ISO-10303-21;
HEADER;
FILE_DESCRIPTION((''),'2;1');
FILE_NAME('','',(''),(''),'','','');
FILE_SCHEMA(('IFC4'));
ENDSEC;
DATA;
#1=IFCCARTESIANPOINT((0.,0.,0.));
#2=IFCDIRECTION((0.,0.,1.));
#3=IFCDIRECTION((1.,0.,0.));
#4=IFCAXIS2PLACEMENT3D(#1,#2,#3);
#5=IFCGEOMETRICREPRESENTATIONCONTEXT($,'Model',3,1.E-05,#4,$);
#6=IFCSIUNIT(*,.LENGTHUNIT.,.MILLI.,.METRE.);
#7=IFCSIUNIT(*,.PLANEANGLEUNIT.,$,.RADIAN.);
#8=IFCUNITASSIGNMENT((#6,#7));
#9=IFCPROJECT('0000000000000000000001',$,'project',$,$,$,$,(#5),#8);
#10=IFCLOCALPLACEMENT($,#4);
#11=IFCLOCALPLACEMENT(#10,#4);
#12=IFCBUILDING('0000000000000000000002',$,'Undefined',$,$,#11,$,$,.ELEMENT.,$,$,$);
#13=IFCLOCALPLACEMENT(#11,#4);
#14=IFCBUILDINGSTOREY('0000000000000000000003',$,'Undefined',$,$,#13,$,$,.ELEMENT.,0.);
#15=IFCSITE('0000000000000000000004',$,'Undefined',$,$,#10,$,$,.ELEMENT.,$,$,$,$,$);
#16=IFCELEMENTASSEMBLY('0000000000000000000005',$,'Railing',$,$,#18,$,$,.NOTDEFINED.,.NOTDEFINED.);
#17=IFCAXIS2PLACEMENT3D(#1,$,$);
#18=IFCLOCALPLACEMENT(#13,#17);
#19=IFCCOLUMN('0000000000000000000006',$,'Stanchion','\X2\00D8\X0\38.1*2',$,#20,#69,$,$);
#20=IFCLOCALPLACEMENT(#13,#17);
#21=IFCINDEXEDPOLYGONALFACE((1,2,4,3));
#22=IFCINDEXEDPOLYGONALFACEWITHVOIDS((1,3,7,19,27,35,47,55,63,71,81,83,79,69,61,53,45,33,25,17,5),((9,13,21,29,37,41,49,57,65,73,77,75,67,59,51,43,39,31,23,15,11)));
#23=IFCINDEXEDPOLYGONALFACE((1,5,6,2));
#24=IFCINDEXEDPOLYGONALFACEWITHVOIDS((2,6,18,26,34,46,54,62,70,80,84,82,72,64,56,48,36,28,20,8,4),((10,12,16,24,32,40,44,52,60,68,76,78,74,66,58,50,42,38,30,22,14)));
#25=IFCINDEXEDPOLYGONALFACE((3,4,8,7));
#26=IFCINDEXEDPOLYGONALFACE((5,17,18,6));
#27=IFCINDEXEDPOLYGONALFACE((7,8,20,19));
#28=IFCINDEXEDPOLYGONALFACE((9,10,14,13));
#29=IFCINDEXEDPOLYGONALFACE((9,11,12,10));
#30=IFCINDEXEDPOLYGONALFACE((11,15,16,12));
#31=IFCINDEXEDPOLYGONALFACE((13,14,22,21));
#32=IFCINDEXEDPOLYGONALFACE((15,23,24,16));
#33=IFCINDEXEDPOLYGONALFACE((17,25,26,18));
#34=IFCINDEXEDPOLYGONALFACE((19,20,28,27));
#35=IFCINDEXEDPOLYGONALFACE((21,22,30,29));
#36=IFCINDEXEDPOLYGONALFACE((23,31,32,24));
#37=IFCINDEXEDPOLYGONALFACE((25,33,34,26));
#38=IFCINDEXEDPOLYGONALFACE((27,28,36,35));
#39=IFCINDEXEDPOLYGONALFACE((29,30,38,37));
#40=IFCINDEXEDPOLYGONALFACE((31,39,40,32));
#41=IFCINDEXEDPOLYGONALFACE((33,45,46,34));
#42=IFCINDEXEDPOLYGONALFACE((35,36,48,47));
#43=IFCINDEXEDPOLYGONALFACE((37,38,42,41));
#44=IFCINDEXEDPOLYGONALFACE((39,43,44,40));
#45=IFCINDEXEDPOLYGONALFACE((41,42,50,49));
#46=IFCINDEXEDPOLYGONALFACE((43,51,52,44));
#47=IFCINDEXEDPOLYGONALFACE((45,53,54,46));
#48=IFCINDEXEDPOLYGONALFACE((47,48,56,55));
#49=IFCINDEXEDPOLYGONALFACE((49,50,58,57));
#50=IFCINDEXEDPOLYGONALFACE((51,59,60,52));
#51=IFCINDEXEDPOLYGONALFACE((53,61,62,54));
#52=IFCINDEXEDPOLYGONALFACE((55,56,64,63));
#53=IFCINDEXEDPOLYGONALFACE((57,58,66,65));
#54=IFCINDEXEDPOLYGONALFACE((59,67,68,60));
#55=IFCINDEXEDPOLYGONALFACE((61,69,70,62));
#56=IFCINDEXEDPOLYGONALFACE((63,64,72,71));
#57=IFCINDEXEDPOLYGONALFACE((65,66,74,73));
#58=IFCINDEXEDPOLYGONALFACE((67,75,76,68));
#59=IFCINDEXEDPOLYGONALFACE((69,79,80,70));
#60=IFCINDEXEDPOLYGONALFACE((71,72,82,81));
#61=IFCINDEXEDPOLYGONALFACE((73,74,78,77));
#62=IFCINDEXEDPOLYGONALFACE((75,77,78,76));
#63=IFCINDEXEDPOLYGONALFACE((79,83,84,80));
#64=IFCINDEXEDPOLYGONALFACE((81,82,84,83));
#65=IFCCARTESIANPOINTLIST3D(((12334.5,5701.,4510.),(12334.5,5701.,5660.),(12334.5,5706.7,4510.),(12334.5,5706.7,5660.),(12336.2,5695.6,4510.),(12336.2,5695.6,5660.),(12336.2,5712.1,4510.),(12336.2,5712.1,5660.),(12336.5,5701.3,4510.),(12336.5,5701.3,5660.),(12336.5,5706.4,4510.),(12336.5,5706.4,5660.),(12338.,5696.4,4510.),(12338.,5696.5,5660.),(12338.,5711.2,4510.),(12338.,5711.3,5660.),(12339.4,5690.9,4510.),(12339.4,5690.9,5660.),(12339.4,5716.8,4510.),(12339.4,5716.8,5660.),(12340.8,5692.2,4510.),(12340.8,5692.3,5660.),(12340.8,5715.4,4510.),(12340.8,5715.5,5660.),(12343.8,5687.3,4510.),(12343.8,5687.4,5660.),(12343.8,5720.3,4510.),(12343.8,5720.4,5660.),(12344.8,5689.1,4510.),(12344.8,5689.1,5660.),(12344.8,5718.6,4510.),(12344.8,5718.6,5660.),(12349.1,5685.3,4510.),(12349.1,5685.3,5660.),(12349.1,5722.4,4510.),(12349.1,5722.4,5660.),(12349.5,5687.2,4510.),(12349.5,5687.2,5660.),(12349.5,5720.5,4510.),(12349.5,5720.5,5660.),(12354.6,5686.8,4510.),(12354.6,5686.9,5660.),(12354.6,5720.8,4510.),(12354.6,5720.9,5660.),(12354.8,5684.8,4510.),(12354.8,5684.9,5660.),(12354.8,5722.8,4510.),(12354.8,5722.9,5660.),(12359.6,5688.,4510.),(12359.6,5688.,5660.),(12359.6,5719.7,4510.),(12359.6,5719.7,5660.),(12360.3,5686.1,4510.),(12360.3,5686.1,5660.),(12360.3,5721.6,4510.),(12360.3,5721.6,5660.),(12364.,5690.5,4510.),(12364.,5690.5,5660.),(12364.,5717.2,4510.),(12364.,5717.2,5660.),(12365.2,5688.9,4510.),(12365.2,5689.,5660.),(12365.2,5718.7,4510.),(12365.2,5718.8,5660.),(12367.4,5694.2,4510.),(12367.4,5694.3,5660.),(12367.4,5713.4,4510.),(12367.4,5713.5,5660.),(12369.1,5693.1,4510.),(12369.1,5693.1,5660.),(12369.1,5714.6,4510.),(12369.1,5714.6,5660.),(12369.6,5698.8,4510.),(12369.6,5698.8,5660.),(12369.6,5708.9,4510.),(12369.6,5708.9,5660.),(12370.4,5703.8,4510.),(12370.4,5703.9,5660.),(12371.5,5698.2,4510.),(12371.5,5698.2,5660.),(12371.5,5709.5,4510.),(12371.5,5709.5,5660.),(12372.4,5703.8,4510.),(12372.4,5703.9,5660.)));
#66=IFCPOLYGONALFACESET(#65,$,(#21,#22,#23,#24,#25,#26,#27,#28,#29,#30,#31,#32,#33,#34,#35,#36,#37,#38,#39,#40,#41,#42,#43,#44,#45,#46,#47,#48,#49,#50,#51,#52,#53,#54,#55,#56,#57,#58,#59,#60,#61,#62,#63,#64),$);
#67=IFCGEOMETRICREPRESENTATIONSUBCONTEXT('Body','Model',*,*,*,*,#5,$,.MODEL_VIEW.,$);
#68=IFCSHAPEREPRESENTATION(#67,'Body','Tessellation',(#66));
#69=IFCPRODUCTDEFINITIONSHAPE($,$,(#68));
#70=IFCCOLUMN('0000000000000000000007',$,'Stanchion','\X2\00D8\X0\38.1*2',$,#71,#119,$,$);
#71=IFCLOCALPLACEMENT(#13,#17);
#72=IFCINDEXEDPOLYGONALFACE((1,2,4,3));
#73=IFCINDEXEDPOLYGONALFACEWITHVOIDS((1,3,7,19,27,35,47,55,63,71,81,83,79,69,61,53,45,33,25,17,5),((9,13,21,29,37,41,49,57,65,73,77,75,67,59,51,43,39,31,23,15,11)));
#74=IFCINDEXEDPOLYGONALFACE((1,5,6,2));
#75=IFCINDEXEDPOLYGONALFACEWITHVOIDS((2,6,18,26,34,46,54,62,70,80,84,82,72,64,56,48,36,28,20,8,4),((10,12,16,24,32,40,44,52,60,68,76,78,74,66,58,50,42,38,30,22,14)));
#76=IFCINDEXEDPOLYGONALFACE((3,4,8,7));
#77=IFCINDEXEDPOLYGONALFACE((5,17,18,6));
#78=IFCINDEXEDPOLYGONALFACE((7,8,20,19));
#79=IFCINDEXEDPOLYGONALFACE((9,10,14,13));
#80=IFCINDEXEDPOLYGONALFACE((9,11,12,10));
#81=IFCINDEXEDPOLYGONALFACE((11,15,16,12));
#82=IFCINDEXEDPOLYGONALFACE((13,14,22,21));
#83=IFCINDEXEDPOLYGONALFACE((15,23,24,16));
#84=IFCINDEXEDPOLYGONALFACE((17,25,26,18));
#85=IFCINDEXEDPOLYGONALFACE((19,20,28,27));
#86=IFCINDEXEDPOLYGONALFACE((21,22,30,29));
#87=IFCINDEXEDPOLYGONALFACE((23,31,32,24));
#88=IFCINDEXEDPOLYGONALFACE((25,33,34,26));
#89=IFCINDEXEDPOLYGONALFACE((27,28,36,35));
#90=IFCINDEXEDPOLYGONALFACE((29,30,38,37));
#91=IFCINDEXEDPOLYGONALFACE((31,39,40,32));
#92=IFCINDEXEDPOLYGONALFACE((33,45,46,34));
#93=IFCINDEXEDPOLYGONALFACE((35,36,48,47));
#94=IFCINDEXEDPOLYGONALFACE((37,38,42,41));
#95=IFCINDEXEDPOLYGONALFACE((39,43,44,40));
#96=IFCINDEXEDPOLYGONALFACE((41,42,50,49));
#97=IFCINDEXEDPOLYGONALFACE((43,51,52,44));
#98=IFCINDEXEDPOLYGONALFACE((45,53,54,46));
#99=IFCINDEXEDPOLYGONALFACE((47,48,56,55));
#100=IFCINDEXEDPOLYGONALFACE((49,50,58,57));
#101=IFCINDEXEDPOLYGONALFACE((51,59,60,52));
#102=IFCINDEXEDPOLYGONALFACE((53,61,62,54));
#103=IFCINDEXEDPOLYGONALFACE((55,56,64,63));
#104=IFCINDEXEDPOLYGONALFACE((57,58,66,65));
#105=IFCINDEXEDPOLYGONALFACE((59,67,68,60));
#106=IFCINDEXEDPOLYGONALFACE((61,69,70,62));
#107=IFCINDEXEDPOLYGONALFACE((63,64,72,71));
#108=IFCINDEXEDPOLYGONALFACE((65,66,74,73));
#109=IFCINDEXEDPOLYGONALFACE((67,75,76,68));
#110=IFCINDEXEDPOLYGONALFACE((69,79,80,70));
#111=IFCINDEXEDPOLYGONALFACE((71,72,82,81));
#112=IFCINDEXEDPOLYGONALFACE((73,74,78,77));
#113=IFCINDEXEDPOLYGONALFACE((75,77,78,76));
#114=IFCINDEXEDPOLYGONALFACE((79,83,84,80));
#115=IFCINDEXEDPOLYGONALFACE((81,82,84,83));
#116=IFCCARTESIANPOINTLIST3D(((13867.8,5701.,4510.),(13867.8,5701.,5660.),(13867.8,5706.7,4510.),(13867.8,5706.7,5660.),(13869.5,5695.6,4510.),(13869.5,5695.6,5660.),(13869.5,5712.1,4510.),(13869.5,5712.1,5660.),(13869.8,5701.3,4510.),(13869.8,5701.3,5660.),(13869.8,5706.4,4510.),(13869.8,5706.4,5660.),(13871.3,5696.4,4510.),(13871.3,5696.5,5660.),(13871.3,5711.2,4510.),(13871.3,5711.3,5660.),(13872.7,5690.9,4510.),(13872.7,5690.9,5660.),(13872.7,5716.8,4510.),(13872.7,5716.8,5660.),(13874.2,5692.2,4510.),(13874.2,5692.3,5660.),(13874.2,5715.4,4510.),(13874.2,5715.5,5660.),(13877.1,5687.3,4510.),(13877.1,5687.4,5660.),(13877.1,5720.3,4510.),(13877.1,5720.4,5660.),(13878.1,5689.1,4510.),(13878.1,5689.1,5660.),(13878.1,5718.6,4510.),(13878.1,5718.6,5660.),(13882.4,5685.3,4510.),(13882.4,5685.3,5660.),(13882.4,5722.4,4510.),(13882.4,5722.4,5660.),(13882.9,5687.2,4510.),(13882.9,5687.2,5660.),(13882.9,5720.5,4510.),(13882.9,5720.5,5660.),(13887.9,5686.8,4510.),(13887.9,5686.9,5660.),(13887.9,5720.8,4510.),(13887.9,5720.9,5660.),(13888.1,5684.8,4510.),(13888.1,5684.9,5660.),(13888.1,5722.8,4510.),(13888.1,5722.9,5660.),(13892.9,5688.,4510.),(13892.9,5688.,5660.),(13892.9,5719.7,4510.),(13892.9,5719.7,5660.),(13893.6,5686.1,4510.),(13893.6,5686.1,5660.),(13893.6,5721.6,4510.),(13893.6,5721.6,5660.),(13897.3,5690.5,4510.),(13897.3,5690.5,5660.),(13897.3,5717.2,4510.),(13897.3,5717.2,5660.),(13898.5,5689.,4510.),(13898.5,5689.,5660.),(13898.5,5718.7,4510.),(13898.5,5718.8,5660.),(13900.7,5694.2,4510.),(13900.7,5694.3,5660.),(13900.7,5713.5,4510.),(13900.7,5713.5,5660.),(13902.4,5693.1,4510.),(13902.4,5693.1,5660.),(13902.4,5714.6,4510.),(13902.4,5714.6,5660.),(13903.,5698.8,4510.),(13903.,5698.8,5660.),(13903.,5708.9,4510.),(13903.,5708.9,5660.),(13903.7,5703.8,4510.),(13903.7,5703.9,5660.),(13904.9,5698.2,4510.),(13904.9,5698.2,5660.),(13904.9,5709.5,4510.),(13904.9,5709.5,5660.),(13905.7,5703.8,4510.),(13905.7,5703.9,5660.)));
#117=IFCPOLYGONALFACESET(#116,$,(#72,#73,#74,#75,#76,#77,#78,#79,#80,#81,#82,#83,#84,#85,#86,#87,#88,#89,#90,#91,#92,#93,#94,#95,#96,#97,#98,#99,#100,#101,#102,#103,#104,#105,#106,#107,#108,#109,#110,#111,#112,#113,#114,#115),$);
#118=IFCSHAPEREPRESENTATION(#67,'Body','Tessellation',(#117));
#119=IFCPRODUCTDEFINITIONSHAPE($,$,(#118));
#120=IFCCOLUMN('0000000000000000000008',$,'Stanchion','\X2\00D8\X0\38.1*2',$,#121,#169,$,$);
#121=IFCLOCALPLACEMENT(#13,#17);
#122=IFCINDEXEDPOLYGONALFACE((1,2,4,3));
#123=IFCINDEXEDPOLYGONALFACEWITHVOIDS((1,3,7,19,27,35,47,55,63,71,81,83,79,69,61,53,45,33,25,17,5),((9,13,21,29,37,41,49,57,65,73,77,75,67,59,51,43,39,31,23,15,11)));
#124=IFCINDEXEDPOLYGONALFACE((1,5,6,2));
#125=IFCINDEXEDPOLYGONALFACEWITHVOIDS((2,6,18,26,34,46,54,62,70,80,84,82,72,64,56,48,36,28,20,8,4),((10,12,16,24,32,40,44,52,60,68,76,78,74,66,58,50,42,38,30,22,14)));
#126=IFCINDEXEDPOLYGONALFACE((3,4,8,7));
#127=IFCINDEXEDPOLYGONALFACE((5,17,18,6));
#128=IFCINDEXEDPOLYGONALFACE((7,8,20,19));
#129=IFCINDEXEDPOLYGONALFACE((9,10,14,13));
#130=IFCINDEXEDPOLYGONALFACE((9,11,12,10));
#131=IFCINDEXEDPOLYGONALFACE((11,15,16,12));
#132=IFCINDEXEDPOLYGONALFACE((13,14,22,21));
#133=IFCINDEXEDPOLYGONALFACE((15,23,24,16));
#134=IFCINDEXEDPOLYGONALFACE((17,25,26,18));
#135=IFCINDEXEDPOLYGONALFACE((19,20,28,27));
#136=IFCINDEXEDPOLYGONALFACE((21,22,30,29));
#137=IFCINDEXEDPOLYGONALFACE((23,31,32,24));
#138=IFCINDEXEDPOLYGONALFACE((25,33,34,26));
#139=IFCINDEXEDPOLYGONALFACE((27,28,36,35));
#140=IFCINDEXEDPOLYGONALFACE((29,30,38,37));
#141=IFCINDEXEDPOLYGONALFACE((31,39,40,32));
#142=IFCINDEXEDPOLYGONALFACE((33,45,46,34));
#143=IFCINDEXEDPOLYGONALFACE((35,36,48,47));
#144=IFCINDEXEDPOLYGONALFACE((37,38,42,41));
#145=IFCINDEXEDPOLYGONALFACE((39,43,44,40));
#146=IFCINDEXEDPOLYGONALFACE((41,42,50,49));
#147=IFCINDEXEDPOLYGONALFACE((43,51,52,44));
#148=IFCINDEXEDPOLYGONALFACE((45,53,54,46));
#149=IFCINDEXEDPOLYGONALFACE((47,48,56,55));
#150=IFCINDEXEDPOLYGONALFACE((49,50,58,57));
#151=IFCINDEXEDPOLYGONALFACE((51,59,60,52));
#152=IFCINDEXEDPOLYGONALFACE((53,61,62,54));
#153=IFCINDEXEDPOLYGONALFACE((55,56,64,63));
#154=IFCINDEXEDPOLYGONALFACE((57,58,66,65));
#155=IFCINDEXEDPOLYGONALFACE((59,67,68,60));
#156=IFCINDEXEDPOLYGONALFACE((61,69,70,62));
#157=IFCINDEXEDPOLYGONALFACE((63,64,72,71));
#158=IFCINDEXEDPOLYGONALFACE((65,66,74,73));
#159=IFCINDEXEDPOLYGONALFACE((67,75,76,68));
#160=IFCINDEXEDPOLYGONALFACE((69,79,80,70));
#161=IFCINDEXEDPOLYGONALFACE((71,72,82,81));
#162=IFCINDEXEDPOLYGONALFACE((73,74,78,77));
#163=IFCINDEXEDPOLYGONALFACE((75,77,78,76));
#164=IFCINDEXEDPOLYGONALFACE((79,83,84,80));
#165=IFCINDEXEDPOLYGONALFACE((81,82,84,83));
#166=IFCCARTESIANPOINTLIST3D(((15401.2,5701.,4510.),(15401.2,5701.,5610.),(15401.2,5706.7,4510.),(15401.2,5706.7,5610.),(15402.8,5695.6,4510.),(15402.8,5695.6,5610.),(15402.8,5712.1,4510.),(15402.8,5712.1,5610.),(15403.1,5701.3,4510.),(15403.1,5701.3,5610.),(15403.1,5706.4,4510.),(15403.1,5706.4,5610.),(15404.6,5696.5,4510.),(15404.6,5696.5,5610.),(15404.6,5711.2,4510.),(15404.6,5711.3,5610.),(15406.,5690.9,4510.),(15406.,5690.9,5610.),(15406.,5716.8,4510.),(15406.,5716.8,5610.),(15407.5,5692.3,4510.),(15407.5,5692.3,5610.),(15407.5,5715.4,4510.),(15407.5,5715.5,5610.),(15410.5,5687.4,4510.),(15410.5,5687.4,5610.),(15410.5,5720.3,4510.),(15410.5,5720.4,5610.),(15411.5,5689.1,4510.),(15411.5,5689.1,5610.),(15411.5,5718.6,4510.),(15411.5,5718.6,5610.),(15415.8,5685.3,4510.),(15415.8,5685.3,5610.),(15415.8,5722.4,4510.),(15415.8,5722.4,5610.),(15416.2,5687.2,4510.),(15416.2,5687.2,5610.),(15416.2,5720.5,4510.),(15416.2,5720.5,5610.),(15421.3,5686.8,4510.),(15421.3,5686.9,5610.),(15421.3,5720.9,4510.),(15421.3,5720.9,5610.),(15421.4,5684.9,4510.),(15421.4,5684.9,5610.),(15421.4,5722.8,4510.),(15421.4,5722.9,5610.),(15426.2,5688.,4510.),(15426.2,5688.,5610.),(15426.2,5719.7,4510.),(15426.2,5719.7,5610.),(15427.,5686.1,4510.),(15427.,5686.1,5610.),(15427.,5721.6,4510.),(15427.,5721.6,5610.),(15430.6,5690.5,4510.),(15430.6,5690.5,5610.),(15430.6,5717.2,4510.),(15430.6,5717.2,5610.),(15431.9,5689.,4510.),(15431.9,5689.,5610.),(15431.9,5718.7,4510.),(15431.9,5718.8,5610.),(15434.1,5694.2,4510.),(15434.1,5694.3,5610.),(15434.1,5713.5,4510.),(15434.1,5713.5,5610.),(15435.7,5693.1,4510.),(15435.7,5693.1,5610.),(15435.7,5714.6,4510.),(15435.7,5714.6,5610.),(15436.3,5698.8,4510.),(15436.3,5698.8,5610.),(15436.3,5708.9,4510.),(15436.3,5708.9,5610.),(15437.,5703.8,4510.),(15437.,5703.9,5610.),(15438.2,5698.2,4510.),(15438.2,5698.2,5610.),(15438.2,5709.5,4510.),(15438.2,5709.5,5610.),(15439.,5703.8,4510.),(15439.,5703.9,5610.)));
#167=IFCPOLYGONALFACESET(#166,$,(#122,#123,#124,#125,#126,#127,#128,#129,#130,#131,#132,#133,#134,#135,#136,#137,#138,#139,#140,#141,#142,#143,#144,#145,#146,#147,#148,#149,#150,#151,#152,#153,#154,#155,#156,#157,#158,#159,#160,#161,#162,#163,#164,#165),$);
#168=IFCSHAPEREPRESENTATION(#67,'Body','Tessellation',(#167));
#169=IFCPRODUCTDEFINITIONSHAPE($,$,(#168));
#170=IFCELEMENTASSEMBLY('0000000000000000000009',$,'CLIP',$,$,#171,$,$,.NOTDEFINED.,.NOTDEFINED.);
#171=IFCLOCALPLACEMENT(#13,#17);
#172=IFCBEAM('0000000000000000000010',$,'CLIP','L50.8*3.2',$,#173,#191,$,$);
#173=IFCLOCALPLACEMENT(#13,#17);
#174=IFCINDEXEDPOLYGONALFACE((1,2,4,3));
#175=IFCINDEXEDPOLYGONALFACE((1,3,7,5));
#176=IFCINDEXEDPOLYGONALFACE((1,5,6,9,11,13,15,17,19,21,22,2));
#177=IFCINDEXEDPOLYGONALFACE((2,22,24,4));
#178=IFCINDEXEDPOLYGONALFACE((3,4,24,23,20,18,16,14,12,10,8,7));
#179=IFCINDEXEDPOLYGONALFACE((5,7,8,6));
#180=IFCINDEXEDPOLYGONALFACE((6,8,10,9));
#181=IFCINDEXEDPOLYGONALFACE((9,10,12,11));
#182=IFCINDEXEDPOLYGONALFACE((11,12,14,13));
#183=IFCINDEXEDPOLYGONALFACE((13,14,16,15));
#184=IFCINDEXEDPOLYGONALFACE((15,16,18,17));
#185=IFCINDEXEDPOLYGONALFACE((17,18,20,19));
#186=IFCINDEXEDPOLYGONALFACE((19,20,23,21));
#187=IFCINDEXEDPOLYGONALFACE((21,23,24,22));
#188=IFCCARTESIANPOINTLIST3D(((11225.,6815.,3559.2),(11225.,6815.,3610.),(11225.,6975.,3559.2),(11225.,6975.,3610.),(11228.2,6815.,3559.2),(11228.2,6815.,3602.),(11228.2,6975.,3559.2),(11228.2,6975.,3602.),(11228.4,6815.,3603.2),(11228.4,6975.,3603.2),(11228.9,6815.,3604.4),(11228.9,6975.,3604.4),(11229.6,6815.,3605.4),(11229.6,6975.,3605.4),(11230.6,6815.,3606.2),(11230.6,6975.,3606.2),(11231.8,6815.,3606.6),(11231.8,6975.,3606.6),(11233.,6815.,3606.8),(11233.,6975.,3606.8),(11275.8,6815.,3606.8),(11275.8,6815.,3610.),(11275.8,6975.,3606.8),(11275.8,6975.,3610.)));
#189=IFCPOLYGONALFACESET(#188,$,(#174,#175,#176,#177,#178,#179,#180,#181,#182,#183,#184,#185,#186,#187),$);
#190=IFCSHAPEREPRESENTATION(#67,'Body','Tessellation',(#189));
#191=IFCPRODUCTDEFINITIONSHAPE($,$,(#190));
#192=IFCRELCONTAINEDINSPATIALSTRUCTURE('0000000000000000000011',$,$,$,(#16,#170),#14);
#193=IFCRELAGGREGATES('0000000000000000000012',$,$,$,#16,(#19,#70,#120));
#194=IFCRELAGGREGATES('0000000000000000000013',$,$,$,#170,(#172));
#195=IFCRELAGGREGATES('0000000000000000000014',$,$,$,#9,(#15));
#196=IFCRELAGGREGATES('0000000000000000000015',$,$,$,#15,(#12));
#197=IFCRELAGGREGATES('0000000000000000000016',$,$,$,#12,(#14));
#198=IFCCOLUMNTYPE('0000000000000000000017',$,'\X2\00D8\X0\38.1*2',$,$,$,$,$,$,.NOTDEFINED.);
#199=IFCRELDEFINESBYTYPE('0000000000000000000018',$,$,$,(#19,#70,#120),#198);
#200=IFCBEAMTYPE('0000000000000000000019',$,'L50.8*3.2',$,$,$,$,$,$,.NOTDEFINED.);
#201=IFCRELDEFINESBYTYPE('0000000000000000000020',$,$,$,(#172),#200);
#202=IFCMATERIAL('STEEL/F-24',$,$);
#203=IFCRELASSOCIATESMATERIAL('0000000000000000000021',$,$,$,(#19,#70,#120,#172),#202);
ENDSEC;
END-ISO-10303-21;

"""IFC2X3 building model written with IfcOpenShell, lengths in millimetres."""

from ifc_helpers import new_model, si_unit, frame, origin_with_axes, origin_2d_with_axis, place, context, subcontext, project, spatial, hollow_circle, l_section, extrude, material, type_object, element, aggregate, save


model = new_model("IFC2X3")

# Units and contexts
model_context = context("Model", 3, precision=1e-05, world=origin_with_axes())
body_context = subcontext(model_context, "Body", "Model", "MODEL_VIEW")
ifc_project = project(units=[si_unit("LENGTHUNIT", "METRE", prefix="MILLI"), si_unit("PLANEANGLEUNIT", "RADIAN")], contexts=[model_context])

# Site, building, storey
site_placement = place(None, origin_with_axes())
site = spatial("IfcSite", under=ifc_project, at=site_placement, Name="Undefined", CompositionType="ELEMENT")
building_placement = place(site_placement, origin_with_axes())
building = spatial("IfcBuilding", under=site, at=building_placement, Name="Undefined", CompositionType="ELEMENT")
storey_placement = place(building_placement, origin_with_axes())
storey = spatial("IfcBuildingStorey", under=building, at=storey_placement, Name="Undefined", CompositionType="ELEMENT", Elevation=0.0)

# Element assembly, columns
assembly_1_placement = place(storey_placement, origin_with_axes())
assembly_1 = element("IfcElementAssembly", 1, at=assembly_1_placement, inside=storey, Name="Railing", AssemblyPlace="NOTDEFINED", PredefinedType="NOTDEFINED")
ifc_material_1 = material(Name="STEEL/F-24")
column_type = type_object("IfcColumnType", Name="Ø38.1*2", PredefinedType="NOTDEFINED")
column_1_placement = place(assembly_1_placement, frame((12353.3, 5703.8, 4510.0), z_axis=(0.0, 0.000014, 1.0), x_axis=(0.0, -1.0, 0.000014)))
column_1 = element("IfcColumn", 2, at=column_1_placement, type_object=column_type, material=ifc_material_1, Name="Stanchion", Description="Ø38.1*2", context=body_context, shape_type="SweptSolid", body=[
    extrude(hollow_circle(Radius=19.1, WallThickness=2.0, at=origin_2d_with_axis()), frame((0.0, 0.0, 1150.0), z_axis=(0.0, 0.0, -1.0), x_axis=(0.0, 1.0, 0.0)), (0.0, 0.0, 1.0), 1150.0),
])
column_2_placement = place(assembly_1_placement, frame((13886.7, 5703.8, 4510.0), z_axis=(0.0, 0.000014, 1.0), x_axis=(0.0, -1.0, 0.000014)))
column_2 = element("IfcColumn", 3, at=column_2_placement, type_object=column_type, material=ifc_material_1, Name="Stanchion", Description="Ø38.1*2", context=body_context, shape_type="SweptSolid", body=[
    extrude(hollow_circle(Radius=19.1, WallThickness=2.0, at=origin_2d_with_axis()), frame((0.0, 0.0, 1150.0), z_axis=(0.0, 0.0, -1.0), x_axis=(0.0, 1.0, 0.0)), (0.0, 0.0, 1.0), 1150.0),
])
column_3_placement = place(assembly_1_placement, frame((15420.0, 5703.8, 4510.0), z_axis=(0.0, 0.000014, 1.0), x_axis=(0.000001, -1.0, 0.000014)))
column_3 = element("IfcColumn", 4, at=column_3_placement, type_object=column_type, material=ifc_material_1, Name="Stanchion", Description="Ø38.1*2", context=body_context, shape_type="SweptSolid", body=[
    extrude(hollow_circle(Radius=19.1, WallThickness=2.0, at=origin_2d_with_axis()), frame((0.0, 0.0, 1100.0), z_axis=(0.0, 0.0, -1.0), x_axis=(0.0, 1.0, 0.0)), (0.0, 0.0, 1.0), 1100.0),
])

# Element assembly, beam
assembly_2_placement = place(storey_placement, origin_with_axes())
assembly_2 = element("IfcElementAssembly", 5, at=assembly_2_placement, inside=storey, Name="CLIP", AssemblyPlace="NOTDEFINED", PredefinedType="NOTDEFINED")
beam_type_1 = type_object("IfcBeamType", Name="L50.8*3.2", PredefinedType="NOTDEFINED")
beam_1_placement = place(assembly_2_placement, frame((11250.4, 6975.0, 3584.6), z_axis=(0.0, 0.0, -1.0), x_axis=(0.0, -1.0, 0.0)))
beam_1 = element("IfcBeam", 6, at=beam_1_placement, type_object=beam_type_1, material=ifc_material_1, Name="CLIP", Description="L50.8*3.2", context=body_context, shape_type="SweptSolid", body=[
    extrude(l_section(Depth=50.8, Width=50.8, Thickness=3.2, FilletRadius=4.8, at=origin_2d_with_axis()), frame((160.0, 0.0, 0.0), z_axis=(-1.0, 0.0, 0.0), x_axis=(0.0, -1.0, 0.0)), (0.0, 0.0, 1.0), 160.0),
])

aggregate(assembly_1, [column_1, column_2, column_3])

aggregate(assembly_2, [beam_1])

save(model, "model.ifc")
